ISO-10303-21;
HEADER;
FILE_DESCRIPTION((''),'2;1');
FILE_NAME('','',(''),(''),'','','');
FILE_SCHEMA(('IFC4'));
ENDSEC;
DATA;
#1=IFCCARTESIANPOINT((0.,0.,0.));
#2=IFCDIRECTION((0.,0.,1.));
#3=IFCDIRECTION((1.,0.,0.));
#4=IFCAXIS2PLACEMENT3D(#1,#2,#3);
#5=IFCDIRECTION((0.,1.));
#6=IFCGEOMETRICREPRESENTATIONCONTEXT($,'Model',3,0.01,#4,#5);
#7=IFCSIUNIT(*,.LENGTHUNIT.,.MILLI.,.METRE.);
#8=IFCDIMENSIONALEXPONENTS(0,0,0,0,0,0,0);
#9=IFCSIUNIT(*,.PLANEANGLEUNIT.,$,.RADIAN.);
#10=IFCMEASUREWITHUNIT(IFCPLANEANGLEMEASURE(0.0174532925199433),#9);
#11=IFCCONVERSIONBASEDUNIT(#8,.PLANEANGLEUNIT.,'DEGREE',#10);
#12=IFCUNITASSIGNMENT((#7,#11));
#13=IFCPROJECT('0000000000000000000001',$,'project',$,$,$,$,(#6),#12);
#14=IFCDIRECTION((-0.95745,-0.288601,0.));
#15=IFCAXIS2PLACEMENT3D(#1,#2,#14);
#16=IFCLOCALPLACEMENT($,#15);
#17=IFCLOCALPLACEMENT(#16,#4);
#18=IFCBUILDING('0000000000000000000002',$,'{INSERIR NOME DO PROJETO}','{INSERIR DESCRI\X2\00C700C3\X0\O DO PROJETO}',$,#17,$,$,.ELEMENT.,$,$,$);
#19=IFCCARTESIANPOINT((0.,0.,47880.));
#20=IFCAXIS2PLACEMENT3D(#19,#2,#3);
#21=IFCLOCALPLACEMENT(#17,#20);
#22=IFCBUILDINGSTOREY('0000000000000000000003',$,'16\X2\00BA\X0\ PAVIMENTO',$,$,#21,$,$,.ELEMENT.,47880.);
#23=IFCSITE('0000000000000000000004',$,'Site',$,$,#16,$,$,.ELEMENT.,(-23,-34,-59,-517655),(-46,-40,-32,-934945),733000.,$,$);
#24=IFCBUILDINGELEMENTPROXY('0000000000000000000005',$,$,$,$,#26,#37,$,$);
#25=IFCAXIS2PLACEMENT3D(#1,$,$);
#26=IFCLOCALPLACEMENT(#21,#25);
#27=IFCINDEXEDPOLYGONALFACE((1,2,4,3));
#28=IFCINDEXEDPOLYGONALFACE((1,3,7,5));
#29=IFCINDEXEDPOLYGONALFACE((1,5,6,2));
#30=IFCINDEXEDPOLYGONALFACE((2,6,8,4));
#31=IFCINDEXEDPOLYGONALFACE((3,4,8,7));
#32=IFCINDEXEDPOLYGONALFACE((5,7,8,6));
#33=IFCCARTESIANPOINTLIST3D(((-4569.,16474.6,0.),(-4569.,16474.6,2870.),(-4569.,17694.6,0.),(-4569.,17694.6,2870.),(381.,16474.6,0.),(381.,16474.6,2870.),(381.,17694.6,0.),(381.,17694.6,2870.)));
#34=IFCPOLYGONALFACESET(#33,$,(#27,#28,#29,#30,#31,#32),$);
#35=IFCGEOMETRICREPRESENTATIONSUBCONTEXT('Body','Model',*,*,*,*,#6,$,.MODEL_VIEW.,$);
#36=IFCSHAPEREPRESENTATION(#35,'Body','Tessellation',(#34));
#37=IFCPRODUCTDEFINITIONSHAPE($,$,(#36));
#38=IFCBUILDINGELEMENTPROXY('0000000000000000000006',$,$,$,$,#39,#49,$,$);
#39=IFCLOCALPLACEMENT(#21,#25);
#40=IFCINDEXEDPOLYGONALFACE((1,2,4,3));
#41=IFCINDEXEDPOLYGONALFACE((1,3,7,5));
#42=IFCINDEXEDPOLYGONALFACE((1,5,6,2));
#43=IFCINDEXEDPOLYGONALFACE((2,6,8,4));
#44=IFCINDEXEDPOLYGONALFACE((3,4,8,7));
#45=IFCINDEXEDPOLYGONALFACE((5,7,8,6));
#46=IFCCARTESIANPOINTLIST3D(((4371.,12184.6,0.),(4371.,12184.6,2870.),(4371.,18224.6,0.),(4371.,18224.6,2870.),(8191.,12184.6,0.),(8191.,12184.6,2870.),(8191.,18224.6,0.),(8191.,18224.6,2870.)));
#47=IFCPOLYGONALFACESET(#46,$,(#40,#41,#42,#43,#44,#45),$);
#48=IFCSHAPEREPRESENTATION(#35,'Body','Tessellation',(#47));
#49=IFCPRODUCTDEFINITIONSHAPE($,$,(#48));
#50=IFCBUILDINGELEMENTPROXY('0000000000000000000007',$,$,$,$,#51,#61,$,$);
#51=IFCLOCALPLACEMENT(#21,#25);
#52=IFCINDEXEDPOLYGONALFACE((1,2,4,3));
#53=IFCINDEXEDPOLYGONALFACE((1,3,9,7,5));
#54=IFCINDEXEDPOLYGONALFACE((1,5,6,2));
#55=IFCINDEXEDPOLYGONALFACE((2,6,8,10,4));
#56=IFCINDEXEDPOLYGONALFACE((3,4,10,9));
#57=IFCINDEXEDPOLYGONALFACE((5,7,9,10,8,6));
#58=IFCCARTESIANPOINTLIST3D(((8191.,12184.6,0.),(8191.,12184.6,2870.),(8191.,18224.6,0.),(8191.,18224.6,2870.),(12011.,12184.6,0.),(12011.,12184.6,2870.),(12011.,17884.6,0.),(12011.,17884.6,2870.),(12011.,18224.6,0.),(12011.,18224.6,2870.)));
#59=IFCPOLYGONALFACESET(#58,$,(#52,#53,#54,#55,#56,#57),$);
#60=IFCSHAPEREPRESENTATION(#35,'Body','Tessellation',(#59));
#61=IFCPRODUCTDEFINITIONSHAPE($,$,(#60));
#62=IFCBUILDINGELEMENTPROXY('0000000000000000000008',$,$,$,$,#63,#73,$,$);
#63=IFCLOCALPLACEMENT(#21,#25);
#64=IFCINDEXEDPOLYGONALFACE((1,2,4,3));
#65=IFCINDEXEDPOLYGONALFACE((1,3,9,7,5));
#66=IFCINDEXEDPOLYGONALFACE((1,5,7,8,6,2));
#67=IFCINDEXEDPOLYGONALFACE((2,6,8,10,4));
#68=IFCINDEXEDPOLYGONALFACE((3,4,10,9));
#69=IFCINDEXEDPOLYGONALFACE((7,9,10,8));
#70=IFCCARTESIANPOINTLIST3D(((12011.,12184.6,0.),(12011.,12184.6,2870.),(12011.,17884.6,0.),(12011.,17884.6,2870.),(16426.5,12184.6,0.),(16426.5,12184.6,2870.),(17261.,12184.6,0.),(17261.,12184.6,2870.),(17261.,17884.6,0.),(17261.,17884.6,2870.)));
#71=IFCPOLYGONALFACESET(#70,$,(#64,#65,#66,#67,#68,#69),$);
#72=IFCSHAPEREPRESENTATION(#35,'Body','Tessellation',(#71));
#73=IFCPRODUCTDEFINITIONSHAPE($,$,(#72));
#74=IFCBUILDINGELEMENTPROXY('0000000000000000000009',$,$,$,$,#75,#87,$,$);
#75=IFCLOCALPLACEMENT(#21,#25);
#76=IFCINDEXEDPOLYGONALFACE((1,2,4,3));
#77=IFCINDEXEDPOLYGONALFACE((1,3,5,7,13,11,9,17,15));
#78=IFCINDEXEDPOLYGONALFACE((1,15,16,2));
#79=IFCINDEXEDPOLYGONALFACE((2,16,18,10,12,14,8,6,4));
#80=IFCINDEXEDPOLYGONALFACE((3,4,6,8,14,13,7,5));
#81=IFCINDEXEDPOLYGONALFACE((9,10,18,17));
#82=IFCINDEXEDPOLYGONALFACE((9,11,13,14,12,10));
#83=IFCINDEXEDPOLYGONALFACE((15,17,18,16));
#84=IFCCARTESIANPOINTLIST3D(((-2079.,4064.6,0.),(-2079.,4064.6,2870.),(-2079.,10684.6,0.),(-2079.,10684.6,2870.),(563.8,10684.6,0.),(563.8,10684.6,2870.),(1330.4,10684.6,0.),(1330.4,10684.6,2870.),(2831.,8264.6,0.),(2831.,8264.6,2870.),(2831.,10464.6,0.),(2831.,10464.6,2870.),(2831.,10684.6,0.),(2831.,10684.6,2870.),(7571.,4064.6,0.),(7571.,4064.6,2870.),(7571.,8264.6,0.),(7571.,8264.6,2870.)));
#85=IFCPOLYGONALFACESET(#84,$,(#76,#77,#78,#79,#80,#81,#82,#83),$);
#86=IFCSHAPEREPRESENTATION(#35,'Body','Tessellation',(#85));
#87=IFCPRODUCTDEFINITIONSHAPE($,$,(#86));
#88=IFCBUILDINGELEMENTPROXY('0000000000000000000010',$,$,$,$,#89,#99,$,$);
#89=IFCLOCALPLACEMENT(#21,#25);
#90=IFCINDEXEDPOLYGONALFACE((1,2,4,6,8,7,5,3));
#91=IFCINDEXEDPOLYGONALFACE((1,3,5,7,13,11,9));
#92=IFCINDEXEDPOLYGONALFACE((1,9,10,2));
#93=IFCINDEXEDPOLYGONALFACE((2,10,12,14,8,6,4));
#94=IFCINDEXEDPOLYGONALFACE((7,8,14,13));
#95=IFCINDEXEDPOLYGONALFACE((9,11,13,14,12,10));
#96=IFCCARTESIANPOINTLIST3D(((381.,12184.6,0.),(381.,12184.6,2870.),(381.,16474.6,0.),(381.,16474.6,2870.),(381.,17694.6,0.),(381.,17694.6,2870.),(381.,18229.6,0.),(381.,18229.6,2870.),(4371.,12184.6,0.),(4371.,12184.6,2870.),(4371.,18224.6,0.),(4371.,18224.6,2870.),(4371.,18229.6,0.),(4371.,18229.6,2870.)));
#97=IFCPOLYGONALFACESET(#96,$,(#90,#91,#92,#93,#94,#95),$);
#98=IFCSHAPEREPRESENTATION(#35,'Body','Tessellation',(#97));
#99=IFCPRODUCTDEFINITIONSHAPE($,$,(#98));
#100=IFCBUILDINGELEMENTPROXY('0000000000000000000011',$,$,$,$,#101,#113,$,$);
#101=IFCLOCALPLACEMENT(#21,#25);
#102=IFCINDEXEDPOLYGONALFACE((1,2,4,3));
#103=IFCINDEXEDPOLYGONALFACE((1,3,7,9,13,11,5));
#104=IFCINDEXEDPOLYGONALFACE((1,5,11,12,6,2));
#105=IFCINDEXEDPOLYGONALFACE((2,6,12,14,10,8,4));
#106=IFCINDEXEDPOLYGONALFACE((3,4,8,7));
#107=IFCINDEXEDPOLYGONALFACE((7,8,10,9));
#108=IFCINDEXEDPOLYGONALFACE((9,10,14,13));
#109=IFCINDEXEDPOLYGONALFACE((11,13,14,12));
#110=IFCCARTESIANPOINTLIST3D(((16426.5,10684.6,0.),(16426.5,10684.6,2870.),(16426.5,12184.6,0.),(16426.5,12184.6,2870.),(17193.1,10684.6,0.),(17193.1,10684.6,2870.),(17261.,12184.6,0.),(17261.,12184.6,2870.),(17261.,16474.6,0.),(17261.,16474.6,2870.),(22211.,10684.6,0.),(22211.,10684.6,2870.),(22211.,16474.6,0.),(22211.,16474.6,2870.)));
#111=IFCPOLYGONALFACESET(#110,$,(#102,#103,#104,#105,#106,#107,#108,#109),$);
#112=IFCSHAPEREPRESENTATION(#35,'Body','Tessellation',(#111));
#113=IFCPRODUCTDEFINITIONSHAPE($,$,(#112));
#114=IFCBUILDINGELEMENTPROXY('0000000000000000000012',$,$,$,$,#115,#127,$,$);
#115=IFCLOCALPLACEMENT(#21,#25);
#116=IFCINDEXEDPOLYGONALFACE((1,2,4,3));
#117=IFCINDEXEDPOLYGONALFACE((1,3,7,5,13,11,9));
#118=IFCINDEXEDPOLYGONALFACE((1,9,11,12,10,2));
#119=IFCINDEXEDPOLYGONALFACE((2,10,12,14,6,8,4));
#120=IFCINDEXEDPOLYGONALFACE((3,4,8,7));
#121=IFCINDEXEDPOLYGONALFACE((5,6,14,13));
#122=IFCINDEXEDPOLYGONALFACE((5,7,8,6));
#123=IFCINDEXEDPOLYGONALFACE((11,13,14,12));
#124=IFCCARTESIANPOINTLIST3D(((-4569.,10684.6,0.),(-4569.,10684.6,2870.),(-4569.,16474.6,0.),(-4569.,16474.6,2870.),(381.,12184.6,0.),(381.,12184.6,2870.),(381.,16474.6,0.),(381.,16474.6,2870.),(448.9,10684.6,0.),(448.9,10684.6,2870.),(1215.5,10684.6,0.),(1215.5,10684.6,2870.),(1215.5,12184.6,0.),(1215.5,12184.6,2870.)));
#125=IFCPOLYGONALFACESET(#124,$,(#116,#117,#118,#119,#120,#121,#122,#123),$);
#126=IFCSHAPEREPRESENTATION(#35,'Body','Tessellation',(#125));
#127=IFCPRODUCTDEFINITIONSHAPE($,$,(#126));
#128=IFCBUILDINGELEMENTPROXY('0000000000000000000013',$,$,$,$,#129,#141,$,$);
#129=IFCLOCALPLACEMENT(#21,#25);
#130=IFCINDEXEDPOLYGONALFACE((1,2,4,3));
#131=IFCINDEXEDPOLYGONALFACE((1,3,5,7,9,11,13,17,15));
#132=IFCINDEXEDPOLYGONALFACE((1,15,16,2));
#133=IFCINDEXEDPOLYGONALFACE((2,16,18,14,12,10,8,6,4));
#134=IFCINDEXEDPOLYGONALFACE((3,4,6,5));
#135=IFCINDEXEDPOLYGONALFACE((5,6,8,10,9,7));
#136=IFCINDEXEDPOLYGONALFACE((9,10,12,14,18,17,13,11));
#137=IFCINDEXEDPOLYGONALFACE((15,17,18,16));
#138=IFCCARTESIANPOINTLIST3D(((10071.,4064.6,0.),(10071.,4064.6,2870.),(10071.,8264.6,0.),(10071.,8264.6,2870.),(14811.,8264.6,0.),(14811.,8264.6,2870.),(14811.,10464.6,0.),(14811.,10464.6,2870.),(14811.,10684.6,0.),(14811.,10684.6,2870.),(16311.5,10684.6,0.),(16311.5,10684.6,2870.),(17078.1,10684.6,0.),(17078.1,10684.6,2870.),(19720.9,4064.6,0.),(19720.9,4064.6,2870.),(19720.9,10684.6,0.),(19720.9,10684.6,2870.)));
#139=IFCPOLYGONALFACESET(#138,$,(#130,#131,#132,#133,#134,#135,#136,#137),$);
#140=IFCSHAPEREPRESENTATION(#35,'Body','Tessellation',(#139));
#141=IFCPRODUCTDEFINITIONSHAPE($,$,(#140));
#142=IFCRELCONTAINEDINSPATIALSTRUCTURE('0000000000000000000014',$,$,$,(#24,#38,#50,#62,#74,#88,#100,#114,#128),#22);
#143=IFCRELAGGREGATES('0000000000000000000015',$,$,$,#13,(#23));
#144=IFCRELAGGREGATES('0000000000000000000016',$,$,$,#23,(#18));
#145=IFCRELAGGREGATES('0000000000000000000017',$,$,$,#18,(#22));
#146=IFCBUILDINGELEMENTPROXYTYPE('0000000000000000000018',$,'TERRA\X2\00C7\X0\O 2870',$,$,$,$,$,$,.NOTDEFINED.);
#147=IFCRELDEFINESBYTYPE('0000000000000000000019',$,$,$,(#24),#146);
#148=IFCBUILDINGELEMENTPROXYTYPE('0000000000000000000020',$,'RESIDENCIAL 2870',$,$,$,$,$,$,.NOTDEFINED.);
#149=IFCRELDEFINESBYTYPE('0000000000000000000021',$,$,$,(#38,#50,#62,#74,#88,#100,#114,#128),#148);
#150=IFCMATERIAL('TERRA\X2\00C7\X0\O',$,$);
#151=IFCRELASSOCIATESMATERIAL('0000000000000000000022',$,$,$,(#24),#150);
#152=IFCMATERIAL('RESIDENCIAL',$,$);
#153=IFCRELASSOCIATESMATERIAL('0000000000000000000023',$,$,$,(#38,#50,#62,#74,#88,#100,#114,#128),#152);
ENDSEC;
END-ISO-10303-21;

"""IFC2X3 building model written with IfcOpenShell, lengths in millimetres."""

from ifc_helpers import new_model, entity, si_unit, converted_unit, direction, frame, origin_with_axes, place, context, subcontext, project, spatial, polyline, outline, extrude, material, type_object, element, save


model = new_model("IFC2X3")

# Units and contexts
model_context = context("Model", 3, precision=0.01, world=origin_with_axes(), true_north=direction((0.0, 1.0)))
body_context = subcontext(model_context, "Body", "Model", "MODEL_VIEW")
ifc_project = project(units=[si_unit("LENGTHUNIT", "METRE", prefix="MILLI"), converted_unit("PLANEANGLEUNIT", "DEGREE", entity("IfcPlaneAngleMeasure", 0.0174532925199433), si_unit("PLANEANGLEUNIT", "RADIAN"), dimensions=[0, 0, 0, 0, 0, 0, 0])], contexts=[model_context])

# Site, building, storey
site_placement = place(None, frame((0.0, 0.0, 0.0), z_axis=(0.0, 0.0, 1.0), x_axis=(-0.95745, -0.288601, 0.0)))
site = spatial("IfcSite", under=ifc_project, at=site_placement, Name="Site", CompositionType="ELEMENT", RefLatitude=(-23, -34, -59, -517655), RefLongitude=(-46, -40, -32, -934945), RefElevation=733000.0)
building_placement = place(site_placement, origin_with_axes())
building = spatial("IfcBuilding", under=site, at=building_placement, Name="{INSERIR NOME DO PROJETO}", Description="{INSERIR DESCRIÇÃO DO PROJETO}", CompositionType="ELEMENT")
storey_placement = place(building_placement, frame((0.0, 0.0, 47880.0), z_axis=(0.0, 0.0, 1.0), x_axis=(1.0, 0.0, 0.0)))
storey = spatial("IfcBuildingStorey", under=building, at=storey_placement, Name="16º PAVIMENTO", CompositionType="ELEMENT", Elevation=47880.0)

# Building element proxies
ifc_material_1 = material(Name="TERRAÇO")
building_element_proxy_type_1 = type_object("IfcBuildingElementProxyType", Name="TERRAÇO 2870", PredefinedType="NOTDEFINED")
proxy_1_placement = place(storey_placement, frame((381.0, 17694.6, 0.0), z_axis=(0.0, 0.0, 1.0), x_axis=(1.0, 0.0, 0.0)))
element("IfcBuildingElementProxy", 1, at=proxy_1_placement, inside=storey, type_object=building_element_proxy_type_1, material=ifc_material_1, context=body_context, shape_type="SweptSolid", body=[
    extrude(outline(polyline([(0.0, 0.0), (-4950.0, 0.0), (-4950.0, -1220.0), (0.0, -1220.0), (0.0, 0.0)])), origin_with_axes(), (0.0, 0.0, 1.0), 2870.0),
])
ifc_material_2 = material(Name="RESIDENCIAL")
building_element_proxy_type_2 = type_object("IfcBuildingElementProxyType", Name="RESIDENCIAL 2870", PredefinedType="NOTDEFINED")
proxy_2_placement = place(storey_placement, frame((4371.0, 18224.6, 0.0), z_axis=(0.0, 0.0, 1.0), x_axis=(1.0, 0.0, 0.0)))
element("IfcBuildingElementProxy", 2, at=proxy_2_placement, inside=storey, type_object=building_element_proxy_type_2, material=ifc_material_2, context=body_context, shape_type="SweptSolid", body=[
    extrude(outline(polyline([(0.0, 0.0), (0.0, -6040.0), (3820.0, -6040.0), (3820.0, 0.0), (0.0, 0.0)])), origin_with_axes(), (0.0, 0.0, 1.0), 2870.0),
])
proxy_3_placement = place(storey_placement, frame((8191.0, 18224.6, 0.0), z_axis=(0.0, 0.0, 1.0), x_axis=(1.0, 0.0, 0.0)))
element("IfcBuildingElementProxy", 3, at=proxy_3_placement, inside=storey, type_object=building_element_proxy_type_2, material=ifc_material_2, context=body_context, shape_type="SweptSolid", body=[
    extrude(outline(polyline([(0.0, 0.0), (0.0, -6040.0), (3820.0, -6040.0), (3820.0, -340.0), (3820.0, 0.0), (0.0, 0.0)])), origin_with_axes(), (0.0, 0.0, 1.0), 2870.0),
])
proxy_4_placement = place(storey_placement, frame((12011.0, 12184.6, 0.0), z_axis=(0.0, 0.0, 1.0), x_axis=(1.0, 0.0, 0.0)))
element("IfcBuildingElementProxy", 4, at=proxy_4_placement, inside=storey, type_object=building_element_proxy_type_2, material=ifc_material_2, context=body_context, shape_type="SweptSolid", body=[
    extrude(outline(polyline([(0.0, 0.0), (4415.5, 0.0), (5250.0, 0.0), (5250.0, 5700.0), (0.0, 5700.0), (0.0, 0.0)])), origin_with_axes(), (0.0, 0.0, 1.0), 2870.0),
])
proxy_5_placement = place(storey_placement, frame((-2079.0, 4064.6, 0.0), z_axis=(0.0, 0.0, 1.0), x_axis=(1.0, 0.0, 0.0)))
element("IfcBuildingElementProxy", 5, at=proxy_5_placement, inside=storey, type_object=building_element_proxy_type_2, material=ifc_material_2, context=body_context, shape_type="SweptSolid", body=[
    extrude(outline(polyline([(0.0, 0.0), (9650.0, 0.0), (9650.0, 4200.0), (4910.0, 4200.0), (4910.0, 6400.0), (4910.0, 6620.0), (3409.4, 6620.0), (2642.8, 6620.0), (0.0, 6620.0), (0.0, 0.0)])), origin_with_axes(), (0.0, 0.0, 1.0), 2870.0),
])
proxy_6_placement = place(storey_placement, frame((381.0, 16474.6, 0.0), z_axis=(0.0, 0.0, 1.0), x_axis=(1.0, 0.0, 0.0)))
element("IfcBuildingElementProxy", 6, at=proxy_6_placement, inside=storey, type_object=building_element_proxy_type_2, material=ifc_material_2, context=body_context, shape_type="SweptSolid", body=[
    extrude(outline(polyline([(0.0, 0.0), (0.0, -4290.0), (3990.0, -4290.0), (3990.0, 1750.0), (3990.0, 1755.0), (0.0, 1755.0), (0.0, 1220.0), (0.0, 0.0)])), origin_with_axes(), (0.0, 0.0, 1.0), 2870.0),
])
proxy_7_placement = place(storey_placement, frame((17261.0, 12184.6, 0.0), z_axis=(0.0, 0.0, 1.0), x_axis=(1.0, 0.0, 0.0)))
element("IfcBuildingElementProxy", 7, at=proxy_7_placement, inside=storey, type_object=building_element_proxy_type_2, material=ifc_material_2, context=body_context, shape_type="SweptSolid", body=[
    extrude(outline(polyline([(0.0, 0.0), (-834.5, 0.0), (-834.5, -1500.0), (-67.9, -1500.0), (4950.0, -1500.0), (4950.0, 4290.0), (0.0, 4290.0), (0.0, 0.0)])), origin_with_axes(), (0.0, 0.0, 1.0), 2870.0),
])
proxy_8_placement = place(storey_placement, frame((-4569.0, 16474.6, 0.0), z_axis=(0.0, 0.0, 1.0), x_axis=(1.0, 0.0, 0.0)))
element("IfcBuildingElementProxy", 8, at=proxy_8_placement, inside=storey, type_object=building_element_proxy_type_2, material=ifc_material_2, context=body_context, shape_type="SweptSolid", body=[
    extrude(outline(polyline([(0.0, 0.0), (0.0, -5790.0), (5017.9, -5790.0), (5784.5, -5790.0), (5784.5, -4290.0), (4950.0, -4290.0), (4950.0, 0.0), (0.0, 0.0)])), origin_with_axes(), (0.0, 0.0, 1.0), 2870.0),
])
proxy_9_placement = place(storey_placement, frame((19720.9, 4064.6, 0.0), z_axis=(0.0, 0.0, 1.0), x_axis=(1.0, 0.0, 0.0)))
element("IfcBuildingElementProxy", 9, at=proxy_9_placement, inside=storey, type_object=building_element_proxy_type_2, material=ifc_material_2, context=body_context, shape_type="SweptSolid", body=[
    extrude(outline(polyline([(0.0, 0.0), (0.0, 6620.0), (-2642.8, 6620.0), (-3409.4, 6620.0), (-4910.0, 6620.0), (-4910.0, 6400.0), (-4910.0, 4200.0), (-9650.0, 4200.0), (-9650.0, 0.0), (0.0, 0.0)])), origin_with_axes(), (0.0, 0.0, 1.0), 2870.0),
])

save(model, "model.ifc")
